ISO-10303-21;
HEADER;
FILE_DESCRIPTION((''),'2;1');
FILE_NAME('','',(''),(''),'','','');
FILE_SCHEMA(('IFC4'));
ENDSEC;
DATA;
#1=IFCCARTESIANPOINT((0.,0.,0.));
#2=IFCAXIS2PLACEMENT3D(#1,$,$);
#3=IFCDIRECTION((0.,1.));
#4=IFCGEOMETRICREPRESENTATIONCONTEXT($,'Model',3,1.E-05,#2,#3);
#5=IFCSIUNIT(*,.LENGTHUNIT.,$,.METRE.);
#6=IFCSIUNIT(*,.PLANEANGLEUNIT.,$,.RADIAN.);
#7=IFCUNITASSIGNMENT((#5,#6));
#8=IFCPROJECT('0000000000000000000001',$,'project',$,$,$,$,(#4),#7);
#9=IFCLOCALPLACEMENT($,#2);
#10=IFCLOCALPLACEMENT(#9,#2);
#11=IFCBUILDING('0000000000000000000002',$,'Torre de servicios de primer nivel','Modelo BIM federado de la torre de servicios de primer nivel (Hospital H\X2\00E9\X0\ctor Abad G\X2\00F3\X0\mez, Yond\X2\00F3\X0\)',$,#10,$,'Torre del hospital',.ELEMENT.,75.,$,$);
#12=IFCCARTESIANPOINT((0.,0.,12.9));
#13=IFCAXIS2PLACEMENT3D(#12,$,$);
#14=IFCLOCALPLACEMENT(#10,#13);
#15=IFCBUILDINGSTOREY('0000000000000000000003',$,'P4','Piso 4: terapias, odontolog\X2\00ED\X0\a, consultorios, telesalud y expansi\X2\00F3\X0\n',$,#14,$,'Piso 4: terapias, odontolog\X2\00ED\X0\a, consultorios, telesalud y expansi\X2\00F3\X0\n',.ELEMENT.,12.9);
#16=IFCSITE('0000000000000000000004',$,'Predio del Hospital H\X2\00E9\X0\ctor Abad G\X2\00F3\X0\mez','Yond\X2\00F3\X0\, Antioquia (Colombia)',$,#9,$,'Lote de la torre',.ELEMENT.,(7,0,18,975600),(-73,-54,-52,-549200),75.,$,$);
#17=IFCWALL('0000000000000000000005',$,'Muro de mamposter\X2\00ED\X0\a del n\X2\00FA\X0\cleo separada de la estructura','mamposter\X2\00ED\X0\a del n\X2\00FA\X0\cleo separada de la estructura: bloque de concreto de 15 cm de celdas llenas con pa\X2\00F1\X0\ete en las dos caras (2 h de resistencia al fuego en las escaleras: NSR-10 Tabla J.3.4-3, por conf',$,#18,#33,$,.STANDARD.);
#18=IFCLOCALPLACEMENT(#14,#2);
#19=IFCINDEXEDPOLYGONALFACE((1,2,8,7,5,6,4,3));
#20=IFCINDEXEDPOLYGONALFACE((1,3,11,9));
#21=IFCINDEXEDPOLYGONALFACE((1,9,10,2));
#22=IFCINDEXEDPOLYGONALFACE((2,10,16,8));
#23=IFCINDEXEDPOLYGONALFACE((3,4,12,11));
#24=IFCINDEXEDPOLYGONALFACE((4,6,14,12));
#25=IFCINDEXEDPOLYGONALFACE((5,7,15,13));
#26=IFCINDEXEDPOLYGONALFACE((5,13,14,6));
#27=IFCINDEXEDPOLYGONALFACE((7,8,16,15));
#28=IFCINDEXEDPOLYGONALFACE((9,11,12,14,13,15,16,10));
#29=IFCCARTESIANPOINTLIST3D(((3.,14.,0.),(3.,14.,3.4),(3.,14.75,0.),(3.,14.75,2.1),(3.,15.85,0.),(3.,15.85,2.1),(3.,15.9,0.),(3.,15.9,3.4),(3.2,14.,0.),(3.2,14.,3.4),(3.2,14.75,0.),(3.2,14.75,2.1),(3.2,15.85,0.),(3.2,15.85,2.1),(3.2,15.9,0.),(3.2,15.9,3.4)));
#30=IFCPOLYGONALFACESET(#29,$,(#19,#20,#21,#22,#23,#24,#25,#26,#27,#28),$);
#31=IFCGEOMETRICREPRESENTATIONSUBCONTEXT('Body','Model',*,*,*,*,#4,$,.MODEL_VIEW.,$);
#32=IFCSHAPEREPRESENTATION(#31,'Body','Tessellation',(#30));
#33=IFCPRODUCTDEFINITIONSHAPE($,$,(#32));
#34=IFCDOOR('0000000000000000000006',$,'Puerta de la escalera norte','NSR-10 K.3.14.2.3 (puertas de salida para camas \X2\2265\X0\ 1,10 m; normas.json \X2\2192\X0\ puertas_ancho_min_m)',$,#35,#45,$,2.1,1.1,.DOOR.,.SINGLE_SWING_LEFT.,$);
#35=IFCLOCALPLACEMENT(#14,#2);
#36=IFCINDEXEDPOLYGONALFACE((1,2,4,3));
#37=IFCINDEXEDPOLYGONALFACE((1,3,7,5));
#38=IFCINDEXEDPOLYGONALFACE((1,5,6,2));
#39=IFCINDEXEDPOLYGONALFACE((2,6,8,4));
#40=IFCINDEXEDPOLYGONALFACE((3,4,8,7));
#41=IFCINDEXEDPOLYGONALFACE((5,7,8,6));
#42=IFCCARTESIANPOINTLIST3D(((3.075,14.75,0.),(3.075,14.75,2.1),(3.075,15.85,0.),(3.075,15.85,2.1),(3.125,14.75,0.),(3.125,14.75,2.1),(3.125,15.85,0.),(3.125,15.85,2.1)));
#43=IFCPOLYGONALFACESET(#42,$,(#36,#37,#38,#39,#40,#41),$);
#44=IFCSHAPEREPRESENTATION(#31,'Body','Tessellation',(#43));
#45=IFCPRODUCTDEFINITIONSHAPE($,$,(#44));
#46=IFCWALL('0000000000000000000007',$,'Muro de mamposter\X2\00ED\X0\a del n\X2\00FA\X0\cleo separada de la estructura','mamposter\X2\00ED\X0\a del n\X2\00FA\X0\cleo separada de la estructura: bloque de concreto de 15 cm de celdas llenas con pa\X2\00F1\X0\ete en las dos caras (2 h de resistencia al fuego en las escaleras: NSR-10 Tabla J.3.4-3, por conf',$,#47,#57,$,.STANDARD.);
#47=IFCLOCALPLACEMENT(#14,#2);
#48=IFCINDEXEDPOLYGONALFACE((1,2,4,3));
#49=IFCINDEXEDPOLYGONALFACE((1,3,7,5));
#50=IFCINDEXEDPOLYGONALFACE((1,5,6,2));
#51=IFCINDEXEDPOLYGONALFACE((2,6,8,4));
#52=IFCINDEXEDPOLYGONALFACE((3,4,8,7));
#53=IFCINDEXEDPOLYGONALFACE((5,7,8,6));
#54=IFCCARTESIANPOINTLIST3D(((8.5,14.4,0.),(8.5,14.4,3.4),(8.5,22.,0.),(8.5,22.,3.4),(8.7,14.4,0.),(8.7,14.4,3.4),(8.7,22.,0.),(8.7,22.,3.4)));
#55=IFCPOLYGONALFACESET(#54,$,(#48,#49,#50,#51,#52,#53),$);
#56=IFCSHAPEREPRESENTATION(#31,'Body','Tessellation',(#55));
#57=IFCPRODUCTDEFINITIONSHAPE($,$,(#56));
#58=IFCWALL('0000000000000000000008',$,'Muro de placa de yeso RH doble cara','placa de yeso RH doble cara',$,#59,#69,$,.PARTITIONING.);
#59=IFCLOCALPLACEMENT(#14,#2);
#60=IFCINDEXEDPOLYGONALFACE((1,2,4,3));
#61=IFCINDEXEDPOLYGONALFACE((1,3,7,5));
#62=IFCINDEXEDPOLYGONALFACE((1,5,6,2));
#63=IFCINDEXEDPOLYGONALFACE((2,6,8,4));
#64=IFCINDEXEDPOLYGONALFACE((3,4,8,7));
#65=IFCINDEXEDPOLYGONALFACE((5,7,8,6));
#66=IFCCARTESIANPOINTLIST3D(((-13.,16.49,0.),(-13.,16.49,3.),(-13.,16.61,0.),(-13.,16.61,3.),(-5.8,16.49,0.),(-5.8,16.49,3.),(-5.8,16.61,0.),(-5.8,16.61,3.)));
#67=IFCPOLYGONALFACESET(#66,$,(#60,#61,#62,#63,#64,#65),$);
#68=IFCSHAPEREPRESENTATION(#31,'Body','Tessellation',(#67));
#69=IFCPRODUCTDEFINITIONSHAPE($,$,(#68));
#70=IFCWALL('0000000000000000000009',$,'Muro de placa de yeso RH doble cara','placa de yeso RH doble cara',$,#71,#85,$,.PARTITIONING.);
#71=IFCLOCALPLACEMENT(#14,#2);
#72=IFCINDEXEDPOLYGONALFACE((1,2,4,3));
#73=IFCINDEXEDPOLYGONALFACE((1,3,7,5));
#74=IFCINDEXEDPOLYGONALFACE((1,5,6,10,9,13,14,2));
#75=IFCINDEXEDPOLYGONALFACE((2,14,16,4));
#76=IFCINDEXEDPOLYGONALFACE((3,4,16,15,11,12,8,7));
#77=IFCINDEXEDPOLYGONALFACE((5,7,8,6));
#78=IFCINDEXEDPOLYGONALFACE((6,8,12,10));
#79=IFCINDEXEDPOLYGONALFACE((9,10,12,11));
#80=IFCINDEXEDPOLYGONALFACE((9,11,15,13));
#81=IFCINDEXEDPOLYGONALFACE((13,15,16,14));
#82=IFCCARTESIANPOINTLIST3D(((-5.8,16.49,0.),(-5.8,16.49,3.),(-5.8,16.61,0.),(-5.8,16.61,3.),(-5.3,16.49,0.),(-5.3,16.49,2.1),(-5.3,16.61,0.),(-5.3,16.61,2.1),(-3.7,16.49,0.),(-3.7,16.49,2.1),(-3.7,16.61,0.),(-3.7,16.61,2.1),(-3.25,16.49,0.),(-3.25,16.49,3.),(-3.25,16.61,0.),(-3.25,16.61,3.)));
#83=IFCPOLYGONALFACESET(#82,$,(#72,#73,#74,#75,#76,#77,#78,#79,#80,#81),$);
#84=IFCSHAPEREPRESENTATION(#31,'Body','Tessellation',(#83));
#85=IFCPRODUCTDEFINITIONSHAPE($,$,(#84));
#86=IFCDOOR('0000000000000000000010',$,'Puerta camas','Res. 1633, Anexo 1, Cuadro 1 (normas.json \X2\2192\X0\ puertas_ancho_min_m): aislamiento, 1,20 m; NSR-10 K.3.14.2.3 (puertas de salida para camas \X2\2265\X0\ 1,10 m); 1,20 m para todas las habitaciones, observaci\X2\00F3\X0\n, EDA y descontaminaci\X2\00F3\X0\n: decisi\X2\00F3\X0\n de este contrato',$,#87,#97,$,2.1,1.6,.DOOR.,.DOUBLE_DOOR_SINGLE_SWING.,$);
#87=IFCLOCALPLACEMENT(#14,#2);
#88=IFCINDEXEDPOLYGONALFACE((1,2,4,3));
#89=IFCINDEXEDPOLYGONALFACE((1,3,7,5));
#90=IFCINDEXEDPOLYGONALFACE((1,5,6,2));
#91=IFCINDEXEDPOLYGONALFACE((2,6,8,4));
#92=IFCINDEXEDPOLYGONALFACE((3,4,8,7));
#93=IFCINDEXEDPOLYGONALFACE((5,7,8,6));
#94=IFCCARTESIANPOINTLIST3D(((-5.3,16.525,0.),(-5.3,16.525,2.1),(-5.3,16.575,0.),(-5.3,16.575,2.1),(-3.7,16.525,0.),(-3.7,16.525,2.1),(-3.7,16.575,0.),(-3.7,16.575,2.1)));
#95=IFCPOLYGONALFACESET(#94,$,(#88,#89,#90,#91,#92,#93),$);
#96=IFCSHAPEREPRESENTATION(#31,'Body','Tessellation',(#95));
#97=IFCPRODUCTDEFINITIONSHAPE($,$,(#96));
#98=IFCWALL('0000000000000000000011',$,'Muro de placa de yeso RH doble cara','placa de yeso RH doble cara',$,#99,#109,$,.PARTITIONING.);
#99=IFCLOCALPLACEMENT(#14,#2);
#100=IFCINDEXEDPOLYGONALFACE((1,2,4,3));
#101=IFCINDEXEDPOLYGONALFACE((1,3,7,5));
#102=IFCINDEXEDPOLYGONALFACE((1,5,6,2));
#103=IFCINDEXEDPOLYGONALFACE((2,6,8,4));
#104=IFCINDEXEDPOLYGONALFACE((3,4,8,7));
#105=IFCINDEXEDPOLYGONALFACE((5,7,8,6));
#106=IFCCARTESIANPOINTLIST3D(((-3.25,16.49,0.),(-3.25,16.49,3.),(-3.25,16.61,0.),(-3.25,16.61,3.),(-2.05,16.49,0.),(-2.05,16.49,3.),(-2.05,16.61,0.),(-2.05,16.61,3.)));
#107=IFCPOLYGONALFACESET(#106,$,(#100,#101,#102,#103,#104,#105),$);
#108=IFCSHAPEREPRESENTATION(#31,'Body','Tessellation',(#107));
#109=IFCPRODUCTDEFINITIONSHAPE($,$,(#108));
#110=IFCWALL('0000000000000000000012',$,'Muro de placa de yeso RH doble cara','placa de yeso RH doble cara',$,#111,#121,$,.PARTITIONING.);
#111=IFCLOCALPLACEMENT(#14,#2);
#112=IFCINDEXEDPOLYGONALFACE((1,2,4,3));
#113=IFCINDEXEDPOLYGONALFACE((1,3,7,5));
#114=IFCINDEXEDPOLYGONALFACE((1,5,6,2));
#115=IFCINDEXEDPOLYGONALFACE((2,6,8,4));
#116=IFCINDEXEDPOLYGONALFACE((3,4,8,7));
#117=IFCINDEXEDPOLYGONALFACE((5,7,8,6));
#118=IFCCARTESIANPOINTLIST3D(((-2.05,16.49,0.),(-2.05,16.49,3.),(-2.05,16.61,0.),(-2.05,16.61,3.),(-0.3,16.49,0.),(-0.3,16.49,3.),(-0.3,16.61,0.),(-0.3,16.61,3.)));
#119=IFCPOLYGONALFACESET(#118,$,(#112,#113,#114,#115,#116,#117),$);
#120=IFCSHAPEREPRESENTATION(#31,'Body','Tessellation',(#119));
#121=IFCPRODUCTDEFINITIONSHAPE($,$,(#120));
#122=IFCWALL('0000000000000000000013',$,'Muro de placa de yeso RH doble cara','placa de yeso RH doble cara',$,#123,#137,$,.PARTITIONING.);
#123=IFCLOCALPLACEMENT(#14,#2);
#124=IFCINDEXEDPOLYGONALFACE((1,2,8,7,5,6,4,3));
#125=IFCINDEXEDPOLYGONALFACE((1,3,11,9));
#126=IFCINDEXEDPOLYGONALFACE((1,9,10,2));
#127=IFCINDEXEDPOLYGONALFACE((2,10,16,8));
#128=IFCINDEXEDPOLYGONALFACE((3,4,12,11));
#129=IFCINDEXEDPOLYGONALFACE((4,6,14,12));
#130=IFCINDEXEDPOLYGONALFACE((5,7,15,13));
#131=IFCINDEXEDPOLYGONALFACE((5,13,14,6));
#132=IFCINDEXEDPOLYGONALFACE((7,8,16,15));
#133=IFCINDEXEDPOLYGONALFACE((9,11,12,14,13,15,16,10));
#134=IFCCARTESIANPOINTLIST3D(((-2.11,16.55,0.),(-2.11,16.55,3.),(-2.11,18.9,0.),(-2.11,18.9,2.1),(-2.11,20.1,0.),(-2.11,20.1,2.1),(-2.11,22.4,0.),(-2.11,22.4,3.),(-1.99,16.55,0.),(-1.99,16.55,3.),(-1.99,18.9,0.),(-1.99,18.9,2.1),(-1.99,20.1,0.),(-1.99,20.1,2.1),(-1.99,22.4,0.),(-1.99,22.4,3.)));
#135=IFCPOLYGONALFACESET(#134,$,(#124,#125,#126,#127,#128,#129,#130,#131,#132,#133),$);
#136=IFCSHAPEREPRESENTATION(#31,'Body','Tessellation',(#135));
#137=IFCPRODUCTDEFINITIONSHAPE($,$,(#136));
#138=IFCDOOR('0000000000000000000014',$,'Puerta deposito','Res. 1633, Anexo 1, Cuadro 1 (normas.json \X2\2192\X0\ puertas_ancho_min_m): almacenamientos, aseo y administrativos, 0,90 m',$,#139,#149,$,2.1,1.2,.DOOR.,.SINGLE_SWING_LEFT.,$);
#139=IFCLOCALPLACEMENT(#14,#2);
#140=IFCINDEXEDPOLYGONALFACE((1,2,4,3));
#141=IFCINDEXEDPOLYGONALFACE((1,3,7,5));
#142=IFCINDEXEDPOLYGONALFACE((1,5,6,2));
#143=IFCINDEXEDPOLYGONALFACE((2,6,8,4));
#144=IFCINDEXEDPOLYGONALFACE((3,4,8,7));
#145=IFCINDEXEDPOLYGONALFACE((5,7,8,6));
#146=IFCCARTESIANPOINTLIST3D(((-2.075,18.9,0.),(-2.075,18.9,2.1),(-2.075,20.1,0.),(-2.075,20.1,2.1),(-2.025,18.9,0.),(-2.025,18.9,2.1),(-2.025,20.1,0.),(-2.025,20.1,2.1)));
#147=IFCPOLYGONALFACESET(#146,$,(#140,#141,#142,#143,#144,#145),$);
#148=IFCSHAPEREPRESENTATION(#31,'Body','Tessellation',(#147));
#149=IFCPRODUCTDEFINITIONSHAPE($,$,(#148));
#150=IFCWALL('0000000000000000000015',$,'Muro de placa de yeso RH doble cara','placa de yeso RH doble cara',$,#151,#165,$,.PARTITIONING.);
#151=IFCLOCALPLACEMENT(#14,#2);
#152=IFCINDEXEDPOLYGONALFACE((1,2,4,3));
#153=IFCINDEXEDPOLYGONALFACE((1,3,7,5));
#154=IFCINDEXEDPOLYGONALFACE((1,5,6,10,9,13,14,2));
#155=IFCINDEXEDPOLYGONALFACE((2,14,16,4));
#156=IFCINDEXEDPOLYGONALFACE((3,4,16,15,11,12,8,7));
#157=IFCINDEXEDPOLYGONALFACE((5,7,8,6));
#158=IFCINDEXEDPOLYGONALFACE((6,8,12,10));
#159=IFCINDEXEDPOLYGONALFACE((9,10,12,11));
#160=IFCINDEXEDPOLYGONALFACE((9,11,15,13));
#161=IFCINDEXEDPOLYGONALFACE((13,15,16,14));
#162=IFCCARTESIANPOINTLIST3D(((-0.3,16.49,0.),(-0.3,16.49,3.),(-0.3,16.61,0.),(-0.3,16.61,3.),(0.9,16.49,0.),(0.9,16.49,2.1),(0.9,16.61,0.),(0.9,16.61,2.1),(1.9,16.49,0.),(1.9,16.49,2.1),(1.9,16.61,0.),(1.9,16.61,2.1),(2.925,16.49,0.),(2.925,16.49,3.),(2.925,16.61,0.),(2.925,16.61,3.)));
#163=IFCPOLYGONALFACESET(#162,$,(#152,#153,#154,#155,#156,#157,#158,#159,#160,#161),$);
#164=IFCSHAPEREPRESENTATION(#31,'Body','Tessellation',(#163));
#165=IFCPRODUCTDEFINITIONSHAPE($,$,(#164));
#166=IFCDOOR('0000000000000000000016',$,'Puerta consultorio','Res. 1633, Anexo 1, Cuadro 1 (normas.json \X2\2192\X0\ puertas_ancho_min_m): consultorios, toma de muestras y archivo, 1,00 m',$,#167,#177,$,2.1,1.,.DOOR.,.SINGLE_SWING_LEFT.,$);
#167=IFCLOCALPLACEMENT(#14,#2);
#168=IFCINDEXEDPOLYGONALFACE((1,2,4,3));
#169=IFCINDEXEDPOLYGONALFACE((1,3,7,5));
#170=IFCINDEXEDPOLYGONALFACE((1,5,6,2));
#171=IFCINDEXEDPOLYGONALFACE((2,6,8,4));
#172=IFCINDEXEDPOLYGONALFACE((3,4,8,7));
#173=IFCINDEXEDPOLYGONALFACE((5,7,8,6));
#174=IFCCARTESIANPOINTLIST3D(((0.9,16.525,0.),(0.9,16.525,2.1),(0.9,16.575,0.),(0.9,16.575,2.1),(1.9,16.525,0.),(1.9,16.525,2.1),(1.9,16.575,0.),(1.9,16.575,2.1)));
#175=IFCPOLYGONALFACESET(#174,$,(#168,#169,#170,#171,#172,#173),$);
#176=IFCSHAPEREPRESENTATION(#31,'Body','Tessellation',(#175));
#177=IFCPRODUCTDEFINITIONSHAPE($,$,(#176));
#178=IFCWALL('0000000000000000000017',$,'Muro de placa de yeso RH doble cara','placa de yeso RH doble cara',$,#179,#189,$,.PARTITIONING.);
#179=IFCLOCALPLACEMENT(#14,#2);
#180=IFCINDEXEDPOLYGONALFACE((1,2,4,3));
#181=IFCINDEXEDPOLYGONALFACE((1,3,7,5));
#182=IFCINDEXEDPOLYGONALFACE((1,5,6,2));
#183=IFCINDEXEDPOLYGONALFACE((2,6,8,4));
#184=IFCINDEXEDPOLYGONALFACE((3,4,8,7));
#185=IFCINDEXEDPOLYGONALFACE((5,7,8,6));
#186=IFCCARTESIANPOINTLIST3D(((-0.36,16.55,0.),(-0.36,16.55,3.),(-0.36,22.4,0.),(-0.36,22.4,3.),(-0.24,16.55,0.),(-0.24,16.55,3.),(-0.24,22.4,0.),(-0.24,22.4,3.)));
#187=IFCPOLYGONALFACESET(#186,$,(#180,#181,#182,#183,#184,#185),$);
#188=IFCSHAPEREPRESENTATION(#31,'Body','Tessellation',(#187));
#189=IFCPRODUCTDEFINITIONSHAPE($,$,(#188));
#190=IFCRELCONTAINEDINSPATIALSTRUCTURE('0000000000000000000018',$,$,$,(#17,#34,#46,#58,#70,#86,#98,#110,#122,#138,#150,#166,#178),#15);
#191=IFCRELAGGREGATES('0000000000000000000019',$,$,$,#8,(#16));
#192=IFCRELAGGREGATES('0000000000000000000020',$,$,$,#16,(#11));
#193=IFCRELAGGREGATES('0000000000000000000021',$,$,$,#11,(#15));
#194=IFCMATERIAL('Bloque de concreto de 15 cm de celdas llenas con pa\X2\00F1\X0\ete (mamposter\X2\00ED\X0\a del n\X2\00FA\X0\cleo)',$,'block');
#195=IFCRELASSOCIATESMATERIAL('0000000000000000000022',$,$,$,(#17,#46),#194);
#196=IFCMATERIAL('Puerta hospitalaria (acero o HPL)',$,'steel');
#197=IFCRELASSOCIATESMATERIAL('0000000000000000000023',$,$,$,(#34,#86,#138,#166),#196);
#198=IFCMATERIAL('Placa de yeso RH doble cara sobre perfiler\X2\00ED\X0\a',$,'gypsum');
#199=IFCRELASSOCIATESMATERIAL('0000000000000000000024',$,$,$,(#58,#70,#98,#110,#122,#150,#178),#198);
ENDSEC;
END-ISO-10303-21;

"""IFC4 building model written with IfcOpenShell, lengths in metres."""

from ifc_helpers import new_model, si_unit, direction, frame, origin, place, context, subcontext, project, spatial, rectangle, extrude, material, element, fill, save


model = new_model("IFC4")

# Units and contexts
model_context = context("Model", 3, precision=1e-05, world=origin(), true_north=direction((0.0, 1.0)))
body_context = subcontext(model_context, "Body", "Model", "MODEL_VIEW")
ifc_project = project(units=[si_unit("LENGTHUNIT", "METRE"), si_unit("PLANEANGLEUNIT", "RADIAN")], contexts=[model_context])

# Site, building, storey
site_placement = place(None, origin())
site = spatial("IfcSite", under=ifc_project, at=site_placement, Name="Predio del Hospital Héctor Abad Gómez", Description="Yondó, Antioquia (Colombia)", LongName="Lote de la torre", CompositionType="ELEMENT", RefLatitude=(7, 0, 18, 975600), RefLongitude=(-73, -54, -52, -549200), RefElevation=75.0)
building_placement = place(site_placement, origin())
building = spatial("IfcBuilding", under=site, at=building_placement, Name="Torre de servicios de primer nivel", Description="Modelo BIM federado de la torre de servicios de primer nivel (Hospital Héctor Abad Gómez, Yondó)", LongName="Torre del hospital", CompositionType="ELEMENT", ElevationOfRefHeight=75.0)
placement = place(building_placement, frame((0.0, 0.0, 12.9)))
storey = spatial("IfcBuildingStorey", under=building, at=placement, Name="P4", Description="Piso 4: terapias, odontología, consultorios, telesalud y expansión", LongName="Piso 4: terapias, odontología, consultorios, telesalud y expansión", CompositionType="ELEMENT", Elevation=12.9)

# Wall, opening, door
ifc_material_1 = material(Name="Bloque de concreto de 15 cm de celdas llenas con pañete (mampostería del núcleo)", Category="block")
wall_1 = element("IfcWall", 1, at=placement, inside=storey, material=ifc_material_1, Name="Muro de mampostería del núcleo separada de la estructura", Description="mampostería del núcleo separada de la estructura: bloque de concreto de 15 cm de celdas llenas con pañete en las dos caras (2 h de resistencia al fuego en las escaleras: NSR-10 Tabla J.3.4-3, por conf", PredefinedType="STANDARD", context=body_context, shape_type="SweptSolid", body=[
    extrude(rectangle(XDim=0.2, YDim=1.9), frame((3.1, 14.95, 0.0)), (0.0, 0.0, 1.0), 3.4),
])
opening_1 = element("IfcOpeningElement", 2, at=placement, cuts=wall_1, PredefinedType="OPENING", context=body_context, shape_type="SweptSolid", body=[
    extrude(rectangle(XDim=0.3, YDim=1.1), frame((3.1, 15.3, 0.0)), (0.0, 0.0, 1.0), 2.1),
])
ifc_material_2 = material(Name="Puerta hospitalaria (acero o HPL)", Category="steel")
door_1 = element("IfcDoor", 3, at=placement, inside=storey, material=ifc_material_2, Name="Puerta de la escalera norte", Description="NSR-10 K.3.14.2.3 (puertas de salida para camas ≥ 1,10 m; normas.json → puertas_ancho_min_m)", OperationType="SINGLE_SWING_LEFT", OverallHeight=2.1, OverallWidth=1.1, PredefinedType="DOOR", context=body_context, shape_type="SweptSolid", body=[
    extrude(rectangle(XDim=0.05, YDim=1.1), frame((3.1, 15.3, 0.0)), (0.0, 0.0, 1.0), 2.1),
])
fill(opening_1, door_1)

# Walls
element("IfcWall", 4, at=placement, inside=storey, material=ifc_material_1, Name="Muro de mampostería del núcleo separada de la estructura", Description="mampostería del núcleo separada de la estructura: bloque de concreto de 15 cm de celdas llenas con pañete en las dos caras (2 h de resistencia al fuego en las escaleras: NSR-10 Tabla J.3.4-3, por conf", PredefinedType="STANDARD", context=body_context, shape_type="SweptSolid", body=[
    extrude(rectangle(XDim=0.2, YDim=7.6), frame((8.6, 18.2, 0.0)), (0.0, 0.0, 1.0), 3.4),
])
ifc_material_3 = material(Name="Placa de yeso RH doble cara sobre perfilería", Category="gypsum")
element("IfcWall", 5, at=placement, inside=storey, material=ifc_material_3, Name="Muro de placa de yeso RH doble cara", Description="placa de yeso RH doble cara", PredefinedType="PARTITIONING", context=body_context, shape_type="SweptSolid", body=[
    extrude(rectangle(XDim=7.2, YDim=0.12), frame((-9.4, 16.55, 0.0)), (0.0, 0.0, 1.0), 3.0),
])

# Wall, opening, door
wall_2 = element("IfcWall", 6, at=placement, inside=storey, material=ifc_material_3, Name="Muro de placa de yeso RH doble cara", Description="placa de yeso RH doble cara", PredefinedType="PARTITIONING", context=body_context, shape_type="SweptSolid", body=[
    extrude(rectangle(XDim=2.55, YDim=0.12), frame((-4.525, 16.55, 0.0)), (0.0, 0.0, 1.0), 3.0),
])
opening_2 = element("IfcOpeningElement", 7, at=placement, cuts=wall_2, PredefinedType="OPENING", context=body_context, shape_type="SweptSolid", body=[
    extrude(rectangle(XDim=1.6, YDim=0.22), frame((-4.5, 16.55, 0.0)), (0.0, 0.0, 1.0), 2.1),
])
door_2 = element("IfcDoor", 8, at=placement, inside=storey, material=ifc_material_2, Name="Puerta camas", Description="Res. 1633, Anexo 1, Cuadro 1 (normas.json → puertas_ancho_min_m): aislamiento, 1,20 m; NSR-10 K.3.14.2.3 (puertas de salida para camas ≥ 1,10 m); 1,20 m para todas las habitaciones, observación, EDA y descontaminación: decisión de este contrato", OperationType="DOUBLE_DOOR_SINGLE_SWING", OverallHeight=2.1, OverallWidth=1.6, PredefinedType="DOOR", context=body_context, shape_type="SweptSolid", body=[
    extrude(rectangle(XDim=1.6, YDim=0.05), frame((-4.5, 16.55, 0.0)), (0.0, 0.0, 1.0), 2.1),
])
fill(opening_2, door_2)

# Walls
element("IfcWall", 9, at=placement, inside=storey, material=ifc_material_3, Name="Muro de placa de yeso RH doble cara", Description="placa de yeso RH doble cara", PredefinedType="PARTITIONING", context=body_context, shape_type="SweptSolid", body=[
    extrude(rectangle(XDim=1.2, YDim=0.12), frame((-2.65, 16.55, 0.0)), (0.0, 0.0, 1.0), 3.0),
])
element("IfcWall", 10, at=placement, inside=storey, material=ifc_material_3, Name="Muro de placa de yeso RH doble cara", Description="placa de yeso RH doble cara", PredefinedType="PARTITIONING", context=body_context, shape_type="SweptSolid", body=[
    extrude(rectangle(XDim=1.75, YDim=0.12), frame((-1.175, 16.55, 0.0)), (0.0, 0.0, 1.0), 3.0),
])

# Walls, openings, doors
wall_3 = element("IfcWall", 11, at=placement, inside=storey, material=ifc_material_3, Name="Muro de placa de yeso RH doble cara", Description="placa de yeso RH doble cara", PredefinedType="PARTITIONING", context=body_context, shape_type="SweptSolid", body=[
    extrude(rectangle(XDim=0.12, YDim=5.85), frame((-2.05, 19.475, 0.0)), (0.0, 0.0, 1.0), 3.0),
])
opening_3 = element("IfcOpeningElement", 12, at=placement, cuts=wall_3, PredefinedType="OPENING", context=body_context, shape_type="SweptSolid", body=[
    extrude(rectangle(XDim=0.22, YDim=1.2), frame((-2.05, 19.5, 0.0)), (0.0, 0.0, 1.0), 2.1),
])
door_3 = element("IfcDoor", 13, at=placement, inside=storey, material=ifc_material_2, Name="Puerta deposito", Description="Res. 1633, Anexo 1, Cuadro 1 (normas.json → puertas_ancho_min_m): almacenamientos, aseo y administrativos, 0,90 m", OperationType="SINGLE_SWING_LEFT", OverallHeight=2.1, OverallWidth=1.2, PredefinedType="DOOR", context=body_context, shape_type="SweptSolid", body=[
    extrude(rectangle(XDim=0.05, YDim=1.2), frame((-2.05, 19.5, 0.0)), (0.0, 0.0, 1.0), 2.1),
])
fill(opening_3, door_3)
wall_4 = element("IfcWall", 14, at=placement, inside=storey, material=ifc_material_3, Name="Muro de placa de yeso RH doble cara", Description="placa de yeso RH doble cara", PredefinedType="PARTITIONING", context=body_context, shape_type="SweptSolid", body=[
    extrude(rectangle(XDim=3.225, YDim=0.12), frame((1.3125, 16.55, 0.0)), (0.0, 0.0, 1.0), 3.0),
])
opening_4 = element("IfcOpeningElement", 15, at=placement, cuts=wall_4, PredefinedType="OPENING", context=body_context, shape_type="SweptSolid", body=[
    extrude(rectangle(XDim=1.0, YDim=0.22), frame((1.4, 16.55, 0.0)), (0.0, 0.0, 1.0), 2.1),
])
door_4 = element("IfcDoor", 16, at=placement, inside=storey, material=ifc_material_2, Name="Puerta consultorio", Description="Res. 1633, Anexo 1, Cuadro 1 (normas.json → puertas_ancho_min_m): consultorios, toma de muestras y archivo, 1,00 m", OperationType="SINGLE_SWING_LEFT", OverallHeight=2.1, OverallWidth=1.0, PredefinedType="DOOR", context=body_context, shape_type="SweptSolid", body=[
    extrude(rectangle(XDim=1.0, YDim=0.05), frame((1.4, 16.55, 0.0)), (0.0, 0.0, 1.0), 2.1),
])
fill(opening_4, door_4)

# Wall
element("IfcWall", 17, at=placement, inside=storey, material=ifc_material_3, Name="Muro de placa de yeso RH doble cara", Description="placa de yeso RH doble cara", PredefinedType="PARTITIONING", context=body_context, shape_type="SweptSolid", body=[
    extrude(rectangle(XDim=0.12, YDim=5.85), frame((-0.3, 19.475, 0.0)), (0.0, 0.0, 1.0), 3.0),
])

save(model, "model.ifc")
